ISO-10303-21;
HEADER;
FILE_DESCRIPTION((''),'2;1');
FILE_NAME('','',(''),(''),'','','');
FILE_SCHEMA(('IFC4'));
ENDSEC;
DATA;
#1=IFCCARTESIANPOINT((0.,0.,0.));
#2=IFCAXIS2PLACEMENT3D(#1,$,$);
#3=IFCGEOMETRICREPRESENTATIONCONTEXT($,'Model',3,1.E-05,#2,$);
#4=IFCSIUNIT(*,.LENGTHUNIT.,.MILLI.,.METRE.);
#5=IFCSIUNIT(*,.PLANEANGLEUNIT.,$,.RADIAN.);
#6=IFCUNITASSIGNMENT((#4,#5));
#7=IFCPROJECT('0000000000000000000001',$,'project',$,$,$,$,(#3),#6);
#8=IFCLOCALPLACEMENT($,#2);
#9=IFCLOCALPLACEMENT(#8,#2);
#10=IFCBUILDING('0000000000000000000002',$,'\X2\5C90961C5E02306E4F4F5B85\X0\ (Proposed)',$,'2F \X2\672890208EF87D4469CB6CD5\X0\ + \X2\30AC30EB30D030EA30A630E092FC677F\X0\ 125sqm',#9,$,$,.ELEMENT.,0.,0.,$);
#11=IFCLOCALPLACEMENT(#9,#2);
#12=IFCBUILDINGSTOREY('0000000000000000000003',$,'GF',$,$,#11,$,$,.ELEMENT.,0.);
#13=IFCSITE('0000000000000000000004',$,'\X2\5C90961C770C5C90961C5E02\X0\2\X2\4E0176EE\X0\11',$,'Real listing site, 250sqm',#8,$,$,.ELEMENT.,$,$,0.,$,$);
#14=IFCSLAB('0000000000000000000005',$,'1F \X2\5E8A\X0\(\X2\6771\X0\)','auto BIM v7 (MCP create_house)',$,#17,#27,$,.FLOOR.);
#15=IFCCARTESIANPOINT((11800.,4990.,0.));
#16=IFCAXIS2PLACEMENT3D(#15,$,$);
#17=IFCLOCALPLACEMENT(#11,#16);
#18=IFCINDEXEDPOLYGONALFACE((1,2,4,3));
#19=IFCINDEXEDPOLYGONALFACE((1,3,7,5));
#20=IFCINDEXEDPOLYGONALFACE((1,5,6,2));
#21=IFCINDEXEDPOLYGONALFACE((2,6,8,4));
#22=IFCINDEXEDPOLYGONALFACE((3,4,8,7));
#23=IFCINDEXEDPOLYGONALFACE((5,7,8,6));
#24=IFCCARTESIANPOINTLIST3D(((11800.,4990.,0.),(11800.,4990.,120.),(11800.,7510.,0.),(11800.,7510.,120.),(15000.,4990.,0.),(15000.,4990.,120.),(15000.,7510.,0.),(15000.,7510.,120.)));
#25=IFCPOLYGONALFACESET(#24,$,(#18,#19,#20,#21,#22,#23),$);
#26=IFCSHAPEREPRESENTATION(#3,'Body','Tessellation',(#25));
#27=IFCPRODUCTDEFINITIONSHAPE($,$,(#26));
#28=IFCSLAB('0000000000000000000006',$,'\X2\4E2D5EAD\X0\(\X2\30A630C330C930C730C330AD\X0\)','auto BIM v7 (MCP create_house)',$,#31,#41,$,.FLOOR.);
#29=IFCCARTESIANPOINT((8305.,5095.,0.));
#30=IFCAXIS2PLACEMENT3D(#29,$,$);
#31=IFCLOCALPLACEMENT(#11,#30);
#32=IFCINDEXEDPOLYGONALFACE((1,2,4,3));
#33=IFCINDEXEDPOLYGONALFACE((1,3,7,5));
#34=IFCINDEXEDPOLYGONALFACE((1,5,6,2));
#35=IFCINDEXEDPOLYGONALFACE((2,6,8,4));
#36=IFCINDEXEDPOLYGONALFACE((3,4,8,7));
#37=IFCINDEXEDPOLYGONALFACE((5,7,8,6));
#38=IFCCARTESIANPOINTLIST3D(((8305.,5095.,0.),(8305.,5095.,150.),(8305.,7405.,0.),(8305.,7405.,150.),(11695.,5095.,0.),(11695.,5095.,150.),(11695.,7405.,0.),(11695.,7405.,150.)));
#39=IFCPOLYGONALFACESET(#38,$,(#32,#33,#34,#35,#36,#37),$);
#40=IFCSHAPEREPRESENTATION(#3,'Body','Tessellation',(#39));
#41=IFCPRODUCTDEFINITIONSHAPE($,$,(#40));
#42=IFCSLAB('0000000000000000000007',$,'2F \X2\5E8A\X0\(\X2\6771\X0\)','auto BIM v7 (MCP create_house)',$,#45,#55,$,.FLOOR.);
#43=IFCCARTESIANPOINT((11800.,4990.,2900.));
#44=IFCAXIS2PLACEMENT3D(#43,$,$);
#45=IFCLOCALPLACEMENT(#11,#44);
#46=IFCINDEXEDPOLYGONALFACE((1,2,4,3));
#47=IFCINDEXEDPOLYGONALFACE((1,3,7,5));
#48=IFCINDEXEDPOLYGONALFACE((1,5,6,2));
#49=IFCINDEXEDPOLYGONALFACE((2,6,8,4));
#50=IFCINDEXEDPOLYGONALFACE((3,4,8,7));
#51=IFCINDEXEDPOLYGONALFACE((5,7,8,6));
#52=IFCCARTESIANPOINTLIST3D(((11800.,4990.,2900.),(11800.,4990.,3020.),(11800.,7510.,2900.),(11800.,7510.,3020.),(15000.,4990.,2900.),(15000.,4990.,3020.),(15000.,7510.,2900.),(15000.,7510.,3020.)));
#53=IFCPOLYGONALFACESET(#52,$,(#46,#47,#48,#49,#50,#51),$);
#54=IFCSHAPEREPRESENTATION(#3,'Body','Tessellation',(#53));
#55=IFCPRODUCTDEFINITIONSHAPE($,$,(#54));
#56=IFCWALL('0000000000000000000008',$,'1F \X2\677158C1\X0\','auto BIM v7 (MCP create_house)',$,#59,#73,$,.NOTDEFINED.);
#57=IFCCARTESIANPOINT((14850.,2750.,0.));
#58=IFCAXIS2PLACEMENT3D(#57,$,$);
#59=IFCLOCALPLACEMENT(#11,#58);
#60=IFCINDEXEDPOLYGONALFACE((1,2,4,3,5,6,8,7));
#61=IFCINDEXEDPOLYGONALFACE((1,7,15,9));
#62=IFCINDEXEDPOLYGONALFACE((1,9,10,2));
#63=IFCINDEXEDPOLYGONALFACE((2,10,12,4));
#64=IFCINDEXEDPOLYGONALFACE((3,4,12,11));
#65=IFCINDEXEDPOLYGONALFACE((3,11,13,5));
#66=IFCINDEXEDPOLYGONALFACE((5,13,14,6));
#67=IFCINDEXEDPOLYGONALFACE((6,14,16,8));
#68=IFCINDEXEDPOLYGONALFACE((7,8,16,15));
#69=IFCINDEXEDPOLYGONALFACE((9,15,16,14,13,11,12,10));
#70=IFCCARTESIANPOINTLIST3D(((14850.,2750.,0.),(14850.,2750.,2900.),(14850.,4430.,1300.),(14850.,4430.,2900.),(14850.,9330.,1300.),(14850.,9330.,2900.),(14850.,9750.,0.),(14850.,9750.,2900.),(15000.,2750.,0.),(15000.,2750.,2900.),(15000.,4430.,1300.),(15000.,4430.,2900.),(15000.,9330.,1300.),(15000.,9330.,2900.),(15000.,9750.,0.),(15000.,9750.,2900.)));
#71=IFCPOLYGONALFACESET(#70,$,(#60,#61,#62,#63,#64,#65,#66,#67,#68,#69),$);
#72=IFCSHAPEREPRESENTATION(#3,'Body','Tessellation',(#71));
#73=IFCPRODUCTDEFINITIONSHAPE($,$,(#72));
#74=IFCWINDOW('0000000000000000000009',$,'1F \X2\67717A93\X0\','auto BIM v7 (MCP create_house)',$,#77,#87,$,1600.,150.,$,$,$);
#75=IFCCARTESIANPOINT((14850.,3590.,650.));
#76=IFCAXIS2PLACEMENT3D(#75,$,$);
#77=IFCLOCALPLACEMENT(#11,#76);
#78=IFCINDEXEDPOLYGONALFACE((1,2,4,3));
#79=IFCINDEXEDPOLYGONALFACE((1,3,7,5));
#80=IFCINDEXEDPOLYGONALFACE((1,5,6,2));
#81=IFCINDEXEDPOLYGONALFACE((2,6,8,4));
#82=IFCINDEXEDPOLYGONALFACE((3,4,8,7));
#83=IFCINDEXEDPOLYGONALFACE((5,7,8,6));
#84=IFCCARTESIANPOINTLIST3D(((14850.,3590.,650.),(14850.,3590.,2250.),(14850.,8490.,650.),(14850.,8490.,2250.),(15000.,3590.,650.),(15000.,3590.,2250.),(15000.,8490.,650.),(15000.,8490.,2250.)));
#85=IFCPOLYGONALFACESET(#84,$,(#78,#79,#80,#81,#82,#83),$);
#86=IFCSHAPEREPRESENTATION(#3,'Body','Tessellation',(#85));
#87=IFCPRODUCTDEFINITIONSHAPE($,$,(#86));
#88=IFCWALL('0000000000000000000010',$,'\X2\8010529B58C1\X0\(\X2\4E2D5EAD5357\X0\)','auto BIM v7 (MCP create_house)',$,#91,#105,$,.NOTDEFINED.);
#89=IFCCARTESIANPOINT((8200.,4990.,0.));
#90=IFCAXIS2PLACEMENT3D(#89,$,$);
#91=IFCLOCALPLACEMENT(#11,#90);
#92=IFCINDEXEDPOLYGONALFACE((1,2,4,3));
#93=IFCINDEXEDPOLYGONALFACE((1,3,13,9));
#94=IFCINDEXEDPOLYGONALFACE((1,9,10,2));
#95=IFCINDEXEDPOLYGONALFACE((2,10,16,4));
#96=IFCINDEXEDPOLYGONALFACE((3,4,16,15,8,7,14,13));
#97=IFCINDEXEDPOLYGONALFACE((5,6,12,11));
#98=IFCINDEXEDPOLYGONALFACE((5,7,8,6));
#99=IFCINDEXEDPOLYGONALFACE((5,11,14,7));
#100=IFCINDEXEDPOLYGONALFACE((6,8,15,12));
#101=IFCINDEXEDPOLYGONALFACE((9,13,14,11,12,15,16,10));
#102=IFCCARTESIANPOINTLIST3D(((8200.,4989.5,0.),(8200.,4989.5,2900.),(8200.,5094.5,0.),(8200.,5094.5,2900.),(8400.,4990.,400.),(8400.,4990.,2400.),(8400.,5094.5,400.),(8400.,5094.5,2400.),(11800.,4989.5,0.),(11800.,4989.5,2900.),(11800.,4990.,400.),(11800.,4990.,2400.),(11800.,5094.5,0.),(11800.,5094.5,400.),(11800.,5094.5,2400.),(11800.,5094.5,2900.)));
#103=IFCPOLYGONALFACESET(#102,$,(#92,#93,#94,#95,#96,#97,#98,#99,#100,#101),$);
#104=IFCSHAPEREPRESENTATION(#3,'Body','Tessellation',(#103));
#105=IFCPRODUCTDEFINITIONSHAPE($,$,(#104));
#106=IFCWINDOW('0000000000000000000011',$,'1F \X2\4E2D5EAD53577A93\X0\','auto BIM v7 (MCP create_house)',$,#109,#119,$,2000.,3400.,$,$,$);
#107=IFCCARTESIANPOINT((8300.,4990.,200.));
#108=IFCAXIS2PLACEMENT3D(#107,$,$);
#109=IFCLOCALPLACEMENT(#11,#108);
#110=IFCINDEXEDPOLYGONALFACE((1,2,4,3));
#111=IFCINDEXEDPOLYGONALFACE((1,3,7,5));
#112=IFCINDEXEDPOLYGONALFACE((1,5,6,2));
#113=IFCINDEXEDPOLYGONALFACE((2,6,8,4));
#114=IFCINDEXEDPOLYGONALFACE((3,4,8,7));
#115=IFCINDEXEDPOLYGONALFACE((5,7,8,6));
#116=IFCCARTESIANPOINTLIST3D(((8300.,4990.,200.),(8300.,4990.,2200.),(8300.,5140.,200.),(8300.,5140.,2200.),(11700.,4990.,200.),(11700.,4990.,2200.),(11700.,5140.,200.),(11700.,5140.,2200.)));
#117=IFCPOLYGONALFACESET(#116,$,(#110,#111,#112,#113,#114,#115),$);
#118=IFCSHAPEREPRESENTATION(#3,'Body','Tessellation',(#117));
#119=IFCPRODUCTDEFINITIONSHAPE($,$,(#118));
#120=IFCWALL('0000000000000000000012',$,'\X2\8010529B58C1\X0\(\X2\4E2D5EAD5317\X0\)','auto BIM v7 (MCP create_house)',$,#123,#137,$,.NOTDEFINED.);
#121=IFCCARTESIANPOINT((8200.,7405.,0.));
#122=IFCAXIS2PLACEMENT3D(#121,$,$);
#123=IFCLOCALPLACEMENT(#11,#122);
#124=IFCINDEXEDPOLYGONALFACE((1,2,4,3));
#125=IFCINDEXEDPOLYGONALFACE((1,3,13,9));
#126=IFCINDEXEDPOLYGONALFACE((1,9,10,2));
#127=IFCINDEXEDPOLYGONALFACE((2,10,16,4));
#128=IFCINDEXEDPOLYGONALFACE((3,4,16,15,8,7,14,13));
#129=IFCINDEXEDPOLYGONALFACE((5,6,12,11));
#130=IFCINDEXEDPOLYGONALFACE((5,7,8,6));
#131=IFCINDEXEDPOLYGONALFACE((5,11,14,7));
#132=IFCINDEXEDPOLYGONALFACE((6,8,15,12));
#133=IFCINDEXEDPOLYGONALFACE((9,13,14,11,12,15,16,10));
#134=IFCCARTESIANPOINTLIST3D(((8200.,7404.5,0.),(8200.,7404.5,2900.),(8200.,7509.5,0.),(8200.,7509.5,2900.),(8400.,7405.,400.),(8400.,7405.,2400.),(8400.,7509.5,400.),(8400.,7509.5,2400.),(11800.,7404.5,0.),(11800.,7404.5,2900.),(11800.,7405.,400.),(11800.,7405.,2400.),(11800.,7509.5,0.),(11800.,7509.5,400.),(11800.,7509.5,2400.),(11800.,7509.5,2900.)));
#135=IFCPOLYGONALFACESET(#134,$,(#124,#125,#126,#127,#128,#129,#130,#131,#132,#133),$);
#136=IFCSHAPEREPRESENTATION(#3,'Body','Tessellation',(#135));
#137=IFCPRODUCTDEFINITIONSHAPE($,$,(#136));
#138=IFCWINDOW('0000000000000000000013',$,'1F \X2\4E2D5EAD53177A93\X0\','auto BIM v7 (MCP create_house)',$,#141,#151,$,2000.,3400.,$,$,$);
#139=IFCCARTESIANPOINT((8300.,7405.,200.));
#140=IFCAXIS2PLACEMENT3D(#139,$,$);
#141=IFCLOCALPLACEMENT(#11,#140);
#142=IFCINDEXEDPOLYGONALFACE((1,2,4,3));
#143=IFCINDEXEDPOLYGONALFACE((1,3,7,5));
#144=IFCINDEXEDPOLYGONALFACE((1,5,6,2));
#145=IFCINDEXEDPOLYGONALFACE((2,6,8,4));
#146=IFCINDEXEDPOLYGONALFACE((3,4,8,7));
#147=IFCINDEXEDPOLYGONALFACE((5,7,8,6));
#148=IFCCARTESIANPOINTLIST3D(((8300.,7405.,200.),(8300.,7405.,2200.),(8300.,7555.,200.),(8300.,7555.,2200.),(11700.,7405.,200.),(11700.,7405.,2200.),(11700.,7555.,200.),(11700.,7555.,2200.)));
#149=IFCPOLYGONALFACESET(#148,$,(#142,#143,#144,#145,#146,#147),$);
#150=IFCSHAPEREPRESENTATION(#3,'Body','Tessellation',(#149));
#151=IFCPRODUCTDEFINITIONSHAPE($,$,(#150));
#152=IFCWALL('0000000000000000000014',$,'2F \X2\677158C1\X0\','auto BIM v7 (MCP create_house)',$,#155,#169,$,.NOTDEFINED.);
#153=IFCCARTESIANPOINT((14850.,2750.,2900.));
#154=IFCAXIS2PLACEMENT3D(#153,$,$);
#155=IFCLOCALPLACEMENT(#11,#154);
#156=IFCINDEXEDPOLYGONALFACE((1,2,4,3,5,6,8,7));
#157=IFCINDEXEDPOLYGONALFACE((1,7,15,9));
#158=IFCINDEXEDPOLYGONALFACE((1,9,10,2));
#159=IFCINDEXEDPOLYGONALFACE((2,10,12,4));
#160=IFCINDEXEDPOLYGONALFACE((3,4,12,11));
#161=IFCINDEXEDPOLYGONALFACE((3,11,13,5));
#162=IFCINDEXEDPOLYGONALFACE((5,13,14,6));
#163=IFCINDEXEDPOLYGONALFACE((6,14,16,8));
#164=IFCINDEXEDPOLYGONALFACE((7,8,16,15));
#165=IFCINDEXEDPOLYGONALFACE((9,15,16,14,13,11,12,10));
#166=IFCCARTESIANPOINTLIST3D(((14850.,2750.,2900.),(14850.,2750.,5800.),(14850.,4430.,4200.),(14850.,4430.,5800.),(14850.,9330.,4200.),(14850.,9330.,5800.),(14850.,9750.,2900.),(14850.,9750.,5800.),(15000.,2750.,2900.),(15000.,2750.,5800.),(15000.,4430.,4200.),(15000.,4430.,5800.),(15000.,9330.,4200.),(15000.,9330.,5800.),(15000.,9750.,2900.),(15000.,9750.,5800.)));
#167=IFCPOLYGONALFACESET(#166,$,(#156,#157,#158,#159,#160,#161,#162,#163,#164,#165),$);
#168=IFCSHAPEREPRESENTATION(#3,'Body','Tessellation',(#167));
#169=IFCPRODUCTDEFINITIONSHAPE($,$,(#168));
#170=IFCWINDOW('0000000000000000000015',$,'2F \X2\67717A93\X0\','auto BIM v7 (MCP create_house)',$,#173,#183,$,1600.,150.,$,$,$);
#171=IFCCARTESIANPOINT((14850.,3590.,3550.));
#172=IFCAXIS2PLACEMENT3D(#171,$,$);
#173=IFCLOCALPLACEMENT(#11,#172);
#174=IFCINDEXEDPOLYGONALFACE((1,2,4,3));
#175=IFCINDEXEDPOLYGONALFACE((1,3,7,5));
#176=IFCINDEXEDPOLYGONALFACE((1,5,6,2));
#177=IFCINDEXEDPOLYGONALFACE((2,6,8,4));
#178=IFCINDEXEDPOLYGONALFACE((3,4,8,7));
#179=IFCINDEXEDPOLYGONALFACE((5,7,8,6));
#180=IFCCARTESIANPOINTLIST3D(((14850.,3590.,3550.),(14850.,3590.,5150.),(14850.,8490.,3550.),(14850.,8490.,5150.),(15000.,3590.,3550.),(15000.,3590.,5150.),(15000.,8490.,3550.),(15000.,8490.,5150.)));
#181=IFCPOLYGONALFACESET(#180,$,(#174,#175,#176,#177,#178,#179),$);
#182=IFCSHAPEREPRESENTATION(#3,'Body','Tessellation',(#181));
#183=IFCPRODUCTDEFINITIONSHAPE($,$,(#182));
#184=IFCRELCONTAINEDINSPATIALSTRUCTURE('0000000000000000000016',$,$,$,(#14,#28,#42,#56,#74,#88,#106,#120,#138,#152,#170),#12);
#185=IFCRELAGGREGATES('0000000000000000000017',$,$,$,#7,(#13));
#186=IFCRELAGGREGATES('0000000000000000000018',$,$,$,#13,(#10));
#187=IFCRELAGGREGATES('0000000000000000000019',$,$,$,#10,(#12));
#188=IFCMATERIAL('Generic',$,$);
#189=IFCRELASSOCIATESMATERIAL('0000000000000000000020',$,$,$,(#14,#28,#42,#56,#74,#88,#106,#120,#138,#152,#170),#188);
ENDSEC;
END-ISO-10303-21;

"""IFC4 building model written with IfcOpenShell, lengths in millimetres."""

from ifc_helpers import new_model, si_unit, frame, frame_2d, origin, place, context, project, spatial, rectangle, extrude, material, element, fill, save


model = new_model("IFC4")

# Units and contexts
model_context = context("Model", 3, precision=1e-05, world=origin())
ifc_project = project(units=[si_unit("LENGTHUNIT", "METRE", prefix="MILLI"), si_unit("PLANEANGLEUNIT", "RADIAN")], contexts=[model_context])

# Site, building, storey
site_placement = place(None, origin())
site = spatial("IfcSite", under=ifc_project, at=site_placement, Name="岐阜県岐阜市2丁目11", ObjectType="Real listing site, 250sqm", CompositionType="ELEMENT", RefElevation=0.0)
building_placement = place(site_placement, origin())
building = spatial("IfcBuilding", under=site, at=building_placement, Name="岐阜市の住宅 (Proposed)", ObjectType="2F 木造軸組構法 + ガルバリウム鋼板 125sqm", CompositionType="ELEMENT", ElevationOfRefHeight=0.0, ElevationOfTerrain=0.0)
storey_placement = place(building_placement, origin())
storey = spatial("IfcBuildingStorey", under=building, at=storey_placement, Name="GF", CompositionType="ELEMENT", Elevation=0.0)

# Slabs
ifc_material = material(Name="Generic")
slab_1_placement = place(storey_placement, frame((11800.0, 4990.0, 0.0)))
element("IfcSlab", 1, at=slab_1_placement, inside=storey, material=ifc_material, Name="1F 床(東)", Description="auto BIM v7 (MCP create_house)", PredefinedType="FLOOR", context=model_context, shape_type="SweptSolid", body=[
    extrude(rectangle(XDim=3200.0, YDim=2520.0, at=frame_2d((1600.0, 1260.0))), frame((11800.0, 4990.0, 0.0)), (0.0, 0.0, 1.0), 120.0),
])
slab_2_placement = place(storey_placement, frame((8305.0, 5095.0, 0.0)))
element("IfcSlab", 2, at=slab_2_placement, inside=storey, material=ifc_material, Name="中庭(ウッドデッキ)", Description="auto BIM v7 (MCP create_house)", PredefinedType="FLOOR", context=model_context, shape_type="SweptSolid", body=[
    extrude(rectangle(XDim=3390.0, YDim=2310.0, at=frame_2d((1695.0, 1155.0))), frame((8305.0, 5095.0, 0.0)), (0.0, 0.0, 1.0), 150.0),
])
slab_3_placement = place(storey_placement, frame((11800.0, 4990.0, 2900.0)))
element("IfcSlab", 3, at=slab_3_placement, inside=storey, material=ifc_material, Name="2F 床(東)", Description="auto BIM v7 (MCP create_house)", PredefinedType="FLOOR", context=model_context, shape_type="SweptSolid", body=[
    extrude(rectangle(XDim=3200.0, YDim=2520.0, at=frame_2d((1600.0, 1260.0))), frame((11800.0, 4990.0, 2900.0)), (0.0, 0.0, 1.0), 120.0),
])

# Walls, openings, windows
wall_1_placement = place(storey_placement, frame((14850.0, 2750.0, 0.0)))
wall_1 = element("IfcWall", 4, at=wall_1_placement, inside=storey, material=ifc_material, Name="1F 東壁", Description="auto BIM v7 (MCP create_house)", PredefinedType="NOTDEFINED", context=model_context, shape_type="SweptSolid", body=[
    extrude(rectangle(XDim=150.0, YDim=7000.0, at=frame_2d((75.0, 3500.0))), frame((14850.0, 2750.0, 0.0)), (0.0, 0.0, 1.0), 2900.0),
])
opening_1_placement = place(storey_placement, frame((14850.0, 3590.0, 650.0)))
opening_1 = element("IfcOpeningElement", 5, at=opening_1_placement, cuts=wall_1, PredefinedType="NOTDEFINED", context=model_context, shape_type="SweptSolid", body=[
    extrude(rectangle(XDim=150.0, YDim=4900.0, at=frame_2d((75.0, 2450.0))), frame((14850.0, 3590.0, 650.0)), (0.0, 0.0, 1.0), 1600.0),
])
window_1_placement = place(storey_placement, frame((14850.0, 3590.0, 650.0)))
window_1 = element("IfcWindow", 6, at=window_1_placement, inside=storey, material=ifc_material, Name="1F 東窓", Description="auto BIM v7 (MCP create_house)", OverallHeight=1600.0, OverallWidth=150.0, context=model_context, shape_type="SweptSolid", body=[
    extrude(rectangle(XDim=150.0, YDim=4900.0, at=frame_2d((75.0, 2450.0))), frame((14850.0, 3590.0, 650.0)), (0.0, 0.0, 1.0), 1600.0),
])
fill(opening_1, window_1)
wall_2_placement = place(storey_placement, frame((8200.0, 4990.0, 0.0)))
wall_2 = element("IfcWall", 7, at=wall_2_placement, inside=storey, material=ifc_material, Name="耐力壁(中庭南)", Description="auto BIM v7 (MCP create_house)", PredefinedType="NOTDEFINED", context=model_context, shape_type="SweptSolid", body=[
    extrude(rectangle(XDim=3600.0, YDim=105.0, at=frame_2d((1800.0, 52.0))), frame((8200.0, 4990.0, 0.0)), (0.0, 0.0, 1.0), 2900.0),
])
opening_2_placement = place(storey_placement, frame((8300.0, 4990.0, 200.0)))
opening_2 = element("IfcOpeningElement", 8, at=opening_2_placement, cuts=wall_2, PredefinedType="NOTDEFINED", context=model_context, shape_type="SweptSolid", body=[
    extrude(rectangle(XDim=3400.0, YDim=150.0, at=frame_2d((1700.0, 75.0))), frame((8300.0, 4990.0, 200.0)), (0.0, 0.0, 1.0), 2000.0),
])
window_2_placement = place(storey_placement, frame((8300.0, 4990.0, 200.0)))
window_2 = element("IfcWindow", 9, at=window_2_placement, inside=storey, material=ifc_material, Name="1F 中庭南窓", Description="auto BIM v7 (MCP create_house)", OverallHeight=2000.0, OverallWidth=3400.0, context=model_context, shape_type="SweptSolid", body=[
    extrude(rectangle(XDim=3400.0, YDim=150.0, at=frame_2d((1700.0, 75.0))), frame((8300.0, 4990.0, 200.0)), (0.0, 0.0, 1.0), 2000.0),
])
fill(opening_2, window_2)
wall_3_placement = place(storey_placement, frame((8200.0, 7405.0, 0.0)))
wall_3 = element("IfcWall", 10, at=wall_3_placement, inside=storey, material=ifc_material, Name="耐力壁(中庭北)", Description="auto BIM v7 (MCP create_house)", PredefinedType="NOTDEFINED", context=model_context, shape_type="SweptSolid", body=[
    extrude(rectangle(XDim=3600.0, YDim=105.0, at=frame_2d((1800.0, 52.0))), frame((8200.0, 7405.0, 0.0)), (0.0, 0.0, 1.0), 2900.0),
])
opening_3_placement = place(storey_placement, frame((8300.0, 7405.0, 200.0)))
opening_3 = element("IfcOpeningElement", 11, at=opening_3_placement, cuts=wall_3, PredefinedType="NOTDEFINED", context=model_context, shape_type="SweptSolid", body=[
    extrude(rectangle(XDim=3400.0, YDim=150.0, at=frame_2d((1700.0, 75.0))), frame((8300.0, 7405.0, 200.0)), (0.0, 0.0, 1.0), 2000.0),
])
window_3_placement = place(storey_placement, frame((8300.0, 7405.0, 200.0)))
window_3 = element("IfcWindow", 12, at=window_3_placement, inside=storey, material=ifc_material, Name="1F 中庭北窓", Description="auto BIM v7 (MCP create_house)", OverallHeight=2000.0, OverallWidth=3400.0, context=model_context, shape_type="SweptSolid", body=[
    extrude(rectangle(XDim=3400.0, YDim=150.0, at=frame_2d((1700.0, 75.0))), frame((8300.0, 7405.0, 200.0)), (0.0, 0.0, 1.0), 2000.0),
])
fill(opening_3, window_3)

# Wall, opening, window
wall_4_placement = place(storey_placement, frame((14850.0, 2750.0, 2900.0)))
wall_4 = element("IfcWall", 13, at=wall_4_placement, inside=storey, material=ifc_material, Name="2F 東壁", Description="auto BIM v7 (MCP create_house)", PredefinedType="NOTDEFINED", context=model_context, shape_type="SweptSolid", body=[
    extrude(rectangle(XDim=150.0, YDim=7000.0, at=frame_2d((75.0, 3500.0))), frame((14850.0, 2750.0, 2900.0)), (0.0, 0.0, 1.0), 2900.0),
])
opening_4_placement = place(storey_placement, frame((14850.0, 3590.0, 3550.0)))
opening_4 = element("IfcOpeningElement", 14, at=opening_4_placement, cuts=wall_4, PredefinedType="NOTDEFINED", context=model_context, shape_type="SweptSolid", body=[
    extrude(rectangle(XDim=150.0, YDim=4900.0, at=frame_2d((75.0, 2450.0))), frame((14850.0, 3590.0, 3550.0)), (0.0, 0.0, 1.0), 1600.0),
])
window_4_placement = place(storey_placement, frame((14850.0, 3590.0, 3550.0)))
window_4 = element("IfcWindow", 15, at=window_4_placement, inside=storey, material=ifc_material, Name="2F 東窓", Description="auto BIM v7 (MCP create_house)", OverallHeight=1600.0, OverallWidth=150.0, context=model_context, shape_type="SweptSolid", body=[
    extrude(rectangle(XDim=150.0, YDim=4900.0, at=frame_2d((75.0, 2450.0))), frame((14850.0, 3590.0, 3550.0)), (0.0, 0.0, 1.0), 1600.0),
])
fill(opening_4, window_4)

save(model, "model.ifc")
